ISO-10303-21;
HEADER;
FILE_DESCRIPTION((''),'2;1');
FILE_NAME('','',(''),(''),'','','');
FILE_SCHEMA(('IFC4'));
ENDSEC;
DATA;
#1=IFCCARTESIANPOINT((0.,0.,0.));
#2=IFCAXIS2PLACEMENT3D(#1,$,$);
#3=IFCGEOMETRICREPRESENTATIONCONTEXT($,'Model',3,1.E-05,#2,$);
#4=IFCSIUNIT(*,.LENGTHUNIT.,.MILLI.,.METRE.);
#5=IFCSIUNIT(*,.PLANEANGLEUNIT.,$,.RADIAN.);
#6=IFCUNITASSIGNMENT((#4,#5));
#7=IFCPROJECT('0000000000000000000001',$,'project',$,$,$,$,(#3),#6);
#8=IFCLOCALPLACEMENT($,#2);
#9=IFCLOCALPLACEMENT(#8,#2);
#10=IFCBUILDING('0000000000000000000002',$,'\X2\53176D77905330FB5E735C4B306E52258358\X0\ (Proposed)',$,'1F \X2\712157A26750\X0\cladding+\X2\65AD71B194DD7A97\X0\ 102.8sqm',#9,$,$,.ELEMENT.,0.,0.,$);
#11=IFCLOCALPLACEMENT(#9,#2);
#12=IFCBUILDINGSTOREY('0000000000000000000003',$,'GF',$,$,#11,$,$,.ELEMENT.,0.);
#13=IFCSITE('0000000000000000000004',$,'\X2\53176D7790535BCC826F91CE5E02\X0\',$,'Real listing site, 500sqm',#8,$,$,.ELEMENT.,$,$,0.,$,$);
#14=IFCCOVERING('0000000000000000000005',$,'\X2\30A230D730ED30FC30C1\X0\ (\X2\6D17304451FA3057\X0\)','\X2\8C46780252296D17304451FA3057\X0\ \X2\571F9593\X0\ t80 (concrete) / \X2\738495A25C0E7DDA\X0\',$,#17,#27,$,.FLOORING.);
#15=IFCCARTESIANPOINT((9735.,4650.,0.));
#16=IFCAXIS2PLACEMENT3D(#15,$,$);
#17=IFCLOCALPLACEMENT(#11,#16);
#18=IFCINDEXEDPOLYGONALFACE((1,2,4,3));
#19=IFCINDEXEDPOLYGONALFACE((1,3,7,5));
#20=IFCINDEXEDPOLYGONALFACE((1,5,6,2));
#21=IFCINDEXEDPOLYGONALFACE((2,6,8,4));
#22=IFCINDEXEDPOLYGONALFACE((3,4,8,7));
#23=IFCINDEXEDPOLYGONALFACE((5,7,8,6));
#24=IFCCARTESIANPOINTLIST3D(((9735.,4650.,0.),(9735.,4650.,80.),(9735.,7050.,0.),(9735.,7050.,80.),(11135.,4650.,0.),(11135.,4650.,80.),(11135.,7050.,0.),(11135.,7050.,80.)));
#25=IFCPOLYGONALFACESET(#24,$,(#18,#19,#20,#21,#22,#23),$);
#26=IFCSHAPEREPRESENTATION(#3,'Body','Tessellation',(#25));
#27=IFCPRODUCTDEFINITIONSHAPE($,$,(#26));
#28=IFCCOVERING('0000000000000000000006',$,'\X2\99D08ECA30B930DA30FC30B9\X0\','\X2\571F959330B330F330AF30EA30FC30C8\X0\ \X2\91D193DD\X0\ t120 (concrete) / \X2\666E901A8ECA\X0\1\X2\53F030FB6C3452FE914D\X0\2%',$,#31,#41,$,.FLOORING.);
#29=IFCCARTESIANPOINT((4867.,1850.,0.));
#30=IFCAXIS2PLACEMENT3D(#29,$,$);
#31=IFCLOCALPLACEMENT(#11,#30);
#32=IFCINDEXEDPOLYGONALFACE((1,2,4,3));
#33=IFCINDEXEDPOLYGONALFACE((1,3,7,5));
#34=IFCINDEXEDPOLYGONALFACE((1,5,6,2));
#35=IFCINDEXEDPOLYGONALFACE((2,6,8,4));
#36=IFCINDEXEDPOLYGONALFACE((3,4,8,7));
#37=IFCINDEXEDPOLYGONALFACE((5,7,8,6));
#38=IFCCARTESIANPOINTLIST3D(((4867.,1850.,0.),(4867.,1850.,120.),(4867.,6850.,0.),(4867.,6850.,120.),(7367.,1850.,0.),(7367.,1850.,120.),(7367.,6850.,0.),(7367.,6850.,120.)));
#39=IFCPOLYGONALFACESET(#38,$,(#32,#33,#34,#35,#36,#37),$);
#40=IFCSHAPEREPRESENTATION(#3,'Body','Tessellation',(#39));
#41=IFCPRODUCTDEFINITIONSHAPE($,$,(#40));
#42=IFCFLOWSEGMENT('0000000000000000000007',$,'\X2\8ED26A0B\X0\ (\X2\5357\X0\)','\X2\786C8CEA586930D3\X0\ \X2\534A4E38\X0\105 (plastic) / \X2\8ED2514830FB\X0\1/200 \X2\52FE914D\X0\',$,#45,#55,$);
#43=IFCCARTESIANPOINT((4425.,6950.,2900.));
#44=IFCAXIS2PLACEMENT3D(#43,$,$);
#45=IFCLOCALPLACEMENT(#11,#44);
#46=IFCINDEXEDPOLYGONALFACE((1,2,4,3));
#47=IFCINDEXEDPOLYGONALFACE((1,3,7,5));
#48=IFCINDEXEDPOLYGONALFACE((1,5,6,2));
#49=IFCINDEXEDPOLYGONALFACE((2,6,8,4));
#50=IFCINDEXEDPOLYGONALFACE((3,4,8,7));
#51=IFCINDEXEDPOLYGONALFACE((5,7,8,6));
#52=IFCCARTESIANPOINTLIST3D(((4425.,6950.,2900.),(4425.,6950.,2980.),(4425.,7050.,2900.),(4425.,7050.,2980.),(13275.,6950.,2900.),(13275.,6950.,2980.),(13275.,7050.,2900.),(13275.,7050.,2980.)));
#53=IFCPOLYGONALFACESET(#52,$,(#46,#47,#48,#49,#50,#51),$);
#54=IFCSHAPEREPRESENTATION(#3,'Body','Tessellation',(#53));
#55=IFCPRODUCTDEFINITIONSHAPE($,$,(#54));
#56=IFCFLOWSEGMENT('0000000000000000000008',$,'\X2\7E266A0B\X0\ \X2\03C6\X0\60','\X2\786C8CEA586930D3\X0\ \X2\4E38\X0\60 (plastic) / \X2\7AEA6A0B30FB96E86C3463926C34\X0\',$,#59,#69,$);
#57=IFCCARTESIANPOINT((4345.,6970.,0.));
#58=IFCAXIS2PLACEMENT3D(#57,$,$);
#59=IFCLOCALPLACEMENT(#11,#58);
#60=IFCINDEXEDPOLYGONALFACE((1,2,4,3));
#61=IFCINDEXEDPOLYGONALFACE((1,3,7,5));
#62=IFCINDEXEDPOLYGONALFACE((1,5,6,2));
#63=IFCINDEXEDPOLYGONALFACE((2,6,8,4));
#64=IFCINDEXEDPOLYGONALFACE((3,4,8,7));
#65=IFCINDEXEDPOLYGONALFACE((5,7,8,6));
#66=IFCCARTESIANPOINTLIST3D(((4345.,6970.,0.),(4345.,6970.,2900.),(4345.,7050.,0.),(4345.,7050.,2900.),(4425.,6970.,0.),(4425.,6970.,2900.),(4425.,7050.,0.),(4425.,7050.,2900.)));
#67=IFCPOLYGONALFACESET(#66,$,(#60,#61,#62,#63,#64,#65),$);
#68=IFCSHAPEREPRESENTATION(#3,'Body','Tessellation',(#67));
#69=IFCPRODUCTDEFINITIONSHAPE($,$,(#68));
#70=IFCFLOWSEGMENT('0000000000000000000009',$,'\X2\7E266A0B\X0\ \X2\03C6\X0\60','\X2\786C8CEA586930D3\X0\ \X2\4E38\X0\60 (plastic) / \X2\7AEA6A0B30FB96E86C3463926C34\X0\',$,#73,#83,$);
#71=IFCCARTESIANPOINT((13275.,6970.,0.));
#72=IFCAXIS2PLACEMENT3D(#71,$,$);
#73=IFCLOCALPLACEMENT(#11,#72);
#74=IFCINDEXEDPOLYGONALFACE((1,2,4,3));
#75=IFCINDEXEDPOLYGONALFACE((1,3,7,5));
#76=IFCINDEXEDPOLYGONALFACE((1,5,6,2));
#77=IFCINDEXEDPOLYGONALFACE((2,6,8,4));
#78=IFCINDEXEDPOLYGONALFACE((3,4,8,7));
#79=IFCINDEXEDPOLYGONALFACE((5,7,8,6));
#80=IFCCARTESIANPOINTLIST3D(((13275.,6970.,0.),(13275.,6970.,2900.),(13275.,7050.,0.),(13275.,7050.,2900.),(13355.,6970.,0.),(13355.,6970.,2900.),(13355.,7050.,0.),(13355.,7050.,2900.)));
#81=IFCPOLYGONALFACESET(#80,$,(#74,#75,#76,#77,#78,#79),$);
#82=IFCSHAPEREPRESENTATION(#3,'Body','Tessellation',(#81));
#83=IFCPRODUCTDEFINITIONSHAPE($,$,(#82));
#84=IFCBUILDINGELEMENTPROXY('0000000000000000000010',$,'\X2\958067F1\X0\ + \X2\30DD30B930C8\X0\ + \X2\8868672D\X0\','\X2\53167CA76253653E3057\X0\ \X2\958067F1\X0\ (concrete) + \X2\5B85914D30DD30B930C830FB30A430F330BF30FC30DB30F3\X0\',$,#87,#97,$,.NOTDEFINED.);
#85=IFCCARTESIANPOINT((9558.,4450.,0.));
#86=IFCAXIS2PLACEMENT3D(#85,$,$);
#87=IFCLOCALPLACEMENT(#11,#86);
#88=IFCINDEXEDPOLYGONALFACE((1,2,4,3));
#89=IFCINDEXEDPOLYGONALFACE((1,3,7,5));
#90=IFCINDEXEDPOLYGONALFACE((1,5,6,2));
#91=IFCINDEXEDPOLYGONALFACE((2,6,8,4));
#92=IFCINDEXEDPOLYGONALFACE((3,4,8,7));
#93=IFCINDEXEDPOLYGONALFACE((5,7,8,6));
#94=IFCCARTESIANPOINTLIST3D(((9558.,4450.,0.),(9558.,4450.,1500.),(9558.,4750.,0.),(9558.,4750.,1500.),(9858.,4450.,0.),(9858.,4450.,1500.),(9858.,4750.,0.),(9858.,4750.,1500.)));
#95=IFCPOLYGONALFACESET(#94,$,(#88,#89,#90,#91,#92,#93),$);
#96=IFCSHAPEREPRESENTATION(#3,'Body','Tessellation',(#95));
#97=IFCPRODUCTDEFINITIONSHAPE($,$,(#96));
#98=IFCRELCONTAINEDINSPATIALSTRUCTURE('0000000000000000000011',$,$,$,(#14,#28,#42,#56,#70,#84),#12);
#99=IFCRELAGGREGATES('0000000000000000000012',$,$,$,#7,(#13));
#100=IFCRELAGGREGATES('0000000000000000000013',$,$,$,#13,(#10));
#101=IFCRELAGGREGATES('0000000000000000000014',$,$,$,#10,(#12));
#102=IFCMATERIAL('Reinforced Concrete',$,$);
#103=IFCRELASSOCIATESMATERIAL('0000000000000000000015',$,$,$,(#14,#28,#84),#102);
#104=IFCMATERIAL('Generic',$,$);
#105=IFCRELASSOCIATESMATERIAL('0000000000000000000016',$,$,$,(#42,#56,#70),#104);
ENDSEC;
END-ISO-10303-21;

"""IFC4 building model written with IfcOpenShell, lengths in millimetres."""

from ifc_helpers import new_model, si_unit, frame, frame_2d, origin, place, context, project, spatial, rectangle, extrude, material, element, save


model = new_model("IFC4")

# Units and contexts
model_context = context("Model", 3, precision=1e-05, world=origin())
ifc_project = project(units=[si_unit("LENGTHUNIT", "METRE", prefix="MILLI"), si_unit("PLANEANGLEUNIT", "RADIAN")], contexts=[model_context])

# Site, building, storey
site_placement = place(None, origin())
site = spatial("IfcSite", under=ifc_project, at=site_placement, Name="北海道富良野市", ObjectType="Real listing site, 500sqm", CompositionType="ELEMENT", RefElevation=0.0)
building_placement = place(site_placement, origin())
building = spatial("IfcBuilding", under=site, at=building_placement, Name="北海道・平屋の別荘 (Proposed)", ObjectType="1F 無垢材cladding+断熱铝窗 102.8sqm", CompositionType="ELEMENT", ElevationOfRefHeight=0.0, ElevationOfTerrain=0.0)
storey_placement = place(building_placement, origin())
storey = spatial("IfcBuildingStorey", under=building, at=storey_placement, Name="GF", CompositionType="ELEMENT", Elevation=0.0)

# Shared definitions
ifc_material_1 = material(Name="Reinforced Concrete")

# Coverings
ifc_material_2 = material(Name="Generic")
covering_1_placement = place(storey_placement, frame((9735.0, 4650.0, 0.0)))
element("IfcCovering", 1, at=covering_1_placement, inside=storey, material=ifc_material_1, Name="アプローチ (洗い出し)", Description="豆砂利洗い出し 土間 t80 (concrete) / 玄関導線", PredefinedType="FLOORING", context=model_context, shape_type="SweptSolid", body=[
    extrude(rectangle(XDim=1400.0, YDim=2400.0, at=frame_2d((700.0, 1200.0))), frame((9735.0, 4650.0, 0.0)), (0.0, 0.0, 1.0), 80.0),
])
covering_2_placement = place(storey_placement, frame((4867.0, 1850.0, 0.0)))
element("IfcCovering", 2, at=covering_2_placement, inside=storey, material=ifc_material_1, Name="駐車スペース", Description="土間コンクリート 金鏝 t120 (concrete) / 普通車1台・水勾配2%", PredefinedType="FLOORING", context=model_context, shape_type="SweptSolid", body=[
    extrude(rectangle(XDim=2500.0, YDim=5000.0, at=frame_2d((1250.0, 2500.0))), frame((4867.0, 1850.0, 0.0)), (0.0, 0.0, 1.0), 120.0),
])

# Flow segments
flow_segment_1_placement = place(storey_placement, frame((4425.0, 6950.0, 2900.0)))
element("IfcFlowSegment", 3, at=flow_segment_1_placement, inside=storey, material=ifc_material_2, Name="軒樋 (南)", Description="硬質塩ビ 半丸105 (plastic) / 軒先・1/200 勾配", context=model_context, shape_type="SweptSolid", body=[
    extrude(rectangle(XDim=8850.0, YDim=100.0, at=frame_2d((4425.0, 50.0))), frame((4425.0, 6950.0, 2900.0)), (0.0, 0.0, 1.0), 80.0),
])
flow_segment_2_placement = place(storey_placement, frame((4345.0, 6970.0, 0.0)))
element("IfcFlowSegment", 4, at=flow_segment_2_placement, inside=storey, material=ifc_material_2, Name="縦樋 φ60", Description="硬質塩ビ 丸60 (plastic) / 竪樋・雨水排水", context=model_context, shape_type="SweptSolid", body=[
    extrude(rectangle(XDim=80.0, YDim=80.0, at=frame_2d((40.0, 40.0))), frame((4345.0, 6970.0, 0.0)), (0.0, 0.0, 1.0), 2900.0),
])
flow_segment_3_placement = place(storey_placement, frame((13275.0, 6970.0, 0.0)))
element("IfcFlowSegment", 5, at=flow_segment_3_placement, inside=storey, material=ifc_material_2, Name="縦樋 φ60", Description="硬質塩ビ 丸60 (plastic) / 竪樋・雨水排水", context=model_context, shape_type="SweptSolid", body=[
    extrude(rectangle(XDim=80.0, YDim=80.0, at=frame_2d((40.0, 40.0))), frame((13275.0, 6970.0, 0.0)), (0.0, 0.0, 1.0), 2900.0),
])

# Building element proxy
proxy_placement = place(storey_placement, frame((9558.0, 4450.0, 0.0)))
element("IfcBuildingElementProxy", 6, at=proxy_placement, inside=storey, material=ifc_material_1, Name="門柱 + ポスト + 表札", Description="化粧打放し 門柱 (concrete) + 宅配ポスト・インターホン", PredefinedType="NOTDEFINED", context=model_context, shape_type="SweptSolid", body=[
    extrude(rectangle(XDim=300.0, YDim=300.0, at=frame_2d((150.0, 150.0))), frame((9558.0, 4450.0, 0.0)), (0.0, 0.0, 1.0), 1500.0),
])

save(model, "model.ifc")
